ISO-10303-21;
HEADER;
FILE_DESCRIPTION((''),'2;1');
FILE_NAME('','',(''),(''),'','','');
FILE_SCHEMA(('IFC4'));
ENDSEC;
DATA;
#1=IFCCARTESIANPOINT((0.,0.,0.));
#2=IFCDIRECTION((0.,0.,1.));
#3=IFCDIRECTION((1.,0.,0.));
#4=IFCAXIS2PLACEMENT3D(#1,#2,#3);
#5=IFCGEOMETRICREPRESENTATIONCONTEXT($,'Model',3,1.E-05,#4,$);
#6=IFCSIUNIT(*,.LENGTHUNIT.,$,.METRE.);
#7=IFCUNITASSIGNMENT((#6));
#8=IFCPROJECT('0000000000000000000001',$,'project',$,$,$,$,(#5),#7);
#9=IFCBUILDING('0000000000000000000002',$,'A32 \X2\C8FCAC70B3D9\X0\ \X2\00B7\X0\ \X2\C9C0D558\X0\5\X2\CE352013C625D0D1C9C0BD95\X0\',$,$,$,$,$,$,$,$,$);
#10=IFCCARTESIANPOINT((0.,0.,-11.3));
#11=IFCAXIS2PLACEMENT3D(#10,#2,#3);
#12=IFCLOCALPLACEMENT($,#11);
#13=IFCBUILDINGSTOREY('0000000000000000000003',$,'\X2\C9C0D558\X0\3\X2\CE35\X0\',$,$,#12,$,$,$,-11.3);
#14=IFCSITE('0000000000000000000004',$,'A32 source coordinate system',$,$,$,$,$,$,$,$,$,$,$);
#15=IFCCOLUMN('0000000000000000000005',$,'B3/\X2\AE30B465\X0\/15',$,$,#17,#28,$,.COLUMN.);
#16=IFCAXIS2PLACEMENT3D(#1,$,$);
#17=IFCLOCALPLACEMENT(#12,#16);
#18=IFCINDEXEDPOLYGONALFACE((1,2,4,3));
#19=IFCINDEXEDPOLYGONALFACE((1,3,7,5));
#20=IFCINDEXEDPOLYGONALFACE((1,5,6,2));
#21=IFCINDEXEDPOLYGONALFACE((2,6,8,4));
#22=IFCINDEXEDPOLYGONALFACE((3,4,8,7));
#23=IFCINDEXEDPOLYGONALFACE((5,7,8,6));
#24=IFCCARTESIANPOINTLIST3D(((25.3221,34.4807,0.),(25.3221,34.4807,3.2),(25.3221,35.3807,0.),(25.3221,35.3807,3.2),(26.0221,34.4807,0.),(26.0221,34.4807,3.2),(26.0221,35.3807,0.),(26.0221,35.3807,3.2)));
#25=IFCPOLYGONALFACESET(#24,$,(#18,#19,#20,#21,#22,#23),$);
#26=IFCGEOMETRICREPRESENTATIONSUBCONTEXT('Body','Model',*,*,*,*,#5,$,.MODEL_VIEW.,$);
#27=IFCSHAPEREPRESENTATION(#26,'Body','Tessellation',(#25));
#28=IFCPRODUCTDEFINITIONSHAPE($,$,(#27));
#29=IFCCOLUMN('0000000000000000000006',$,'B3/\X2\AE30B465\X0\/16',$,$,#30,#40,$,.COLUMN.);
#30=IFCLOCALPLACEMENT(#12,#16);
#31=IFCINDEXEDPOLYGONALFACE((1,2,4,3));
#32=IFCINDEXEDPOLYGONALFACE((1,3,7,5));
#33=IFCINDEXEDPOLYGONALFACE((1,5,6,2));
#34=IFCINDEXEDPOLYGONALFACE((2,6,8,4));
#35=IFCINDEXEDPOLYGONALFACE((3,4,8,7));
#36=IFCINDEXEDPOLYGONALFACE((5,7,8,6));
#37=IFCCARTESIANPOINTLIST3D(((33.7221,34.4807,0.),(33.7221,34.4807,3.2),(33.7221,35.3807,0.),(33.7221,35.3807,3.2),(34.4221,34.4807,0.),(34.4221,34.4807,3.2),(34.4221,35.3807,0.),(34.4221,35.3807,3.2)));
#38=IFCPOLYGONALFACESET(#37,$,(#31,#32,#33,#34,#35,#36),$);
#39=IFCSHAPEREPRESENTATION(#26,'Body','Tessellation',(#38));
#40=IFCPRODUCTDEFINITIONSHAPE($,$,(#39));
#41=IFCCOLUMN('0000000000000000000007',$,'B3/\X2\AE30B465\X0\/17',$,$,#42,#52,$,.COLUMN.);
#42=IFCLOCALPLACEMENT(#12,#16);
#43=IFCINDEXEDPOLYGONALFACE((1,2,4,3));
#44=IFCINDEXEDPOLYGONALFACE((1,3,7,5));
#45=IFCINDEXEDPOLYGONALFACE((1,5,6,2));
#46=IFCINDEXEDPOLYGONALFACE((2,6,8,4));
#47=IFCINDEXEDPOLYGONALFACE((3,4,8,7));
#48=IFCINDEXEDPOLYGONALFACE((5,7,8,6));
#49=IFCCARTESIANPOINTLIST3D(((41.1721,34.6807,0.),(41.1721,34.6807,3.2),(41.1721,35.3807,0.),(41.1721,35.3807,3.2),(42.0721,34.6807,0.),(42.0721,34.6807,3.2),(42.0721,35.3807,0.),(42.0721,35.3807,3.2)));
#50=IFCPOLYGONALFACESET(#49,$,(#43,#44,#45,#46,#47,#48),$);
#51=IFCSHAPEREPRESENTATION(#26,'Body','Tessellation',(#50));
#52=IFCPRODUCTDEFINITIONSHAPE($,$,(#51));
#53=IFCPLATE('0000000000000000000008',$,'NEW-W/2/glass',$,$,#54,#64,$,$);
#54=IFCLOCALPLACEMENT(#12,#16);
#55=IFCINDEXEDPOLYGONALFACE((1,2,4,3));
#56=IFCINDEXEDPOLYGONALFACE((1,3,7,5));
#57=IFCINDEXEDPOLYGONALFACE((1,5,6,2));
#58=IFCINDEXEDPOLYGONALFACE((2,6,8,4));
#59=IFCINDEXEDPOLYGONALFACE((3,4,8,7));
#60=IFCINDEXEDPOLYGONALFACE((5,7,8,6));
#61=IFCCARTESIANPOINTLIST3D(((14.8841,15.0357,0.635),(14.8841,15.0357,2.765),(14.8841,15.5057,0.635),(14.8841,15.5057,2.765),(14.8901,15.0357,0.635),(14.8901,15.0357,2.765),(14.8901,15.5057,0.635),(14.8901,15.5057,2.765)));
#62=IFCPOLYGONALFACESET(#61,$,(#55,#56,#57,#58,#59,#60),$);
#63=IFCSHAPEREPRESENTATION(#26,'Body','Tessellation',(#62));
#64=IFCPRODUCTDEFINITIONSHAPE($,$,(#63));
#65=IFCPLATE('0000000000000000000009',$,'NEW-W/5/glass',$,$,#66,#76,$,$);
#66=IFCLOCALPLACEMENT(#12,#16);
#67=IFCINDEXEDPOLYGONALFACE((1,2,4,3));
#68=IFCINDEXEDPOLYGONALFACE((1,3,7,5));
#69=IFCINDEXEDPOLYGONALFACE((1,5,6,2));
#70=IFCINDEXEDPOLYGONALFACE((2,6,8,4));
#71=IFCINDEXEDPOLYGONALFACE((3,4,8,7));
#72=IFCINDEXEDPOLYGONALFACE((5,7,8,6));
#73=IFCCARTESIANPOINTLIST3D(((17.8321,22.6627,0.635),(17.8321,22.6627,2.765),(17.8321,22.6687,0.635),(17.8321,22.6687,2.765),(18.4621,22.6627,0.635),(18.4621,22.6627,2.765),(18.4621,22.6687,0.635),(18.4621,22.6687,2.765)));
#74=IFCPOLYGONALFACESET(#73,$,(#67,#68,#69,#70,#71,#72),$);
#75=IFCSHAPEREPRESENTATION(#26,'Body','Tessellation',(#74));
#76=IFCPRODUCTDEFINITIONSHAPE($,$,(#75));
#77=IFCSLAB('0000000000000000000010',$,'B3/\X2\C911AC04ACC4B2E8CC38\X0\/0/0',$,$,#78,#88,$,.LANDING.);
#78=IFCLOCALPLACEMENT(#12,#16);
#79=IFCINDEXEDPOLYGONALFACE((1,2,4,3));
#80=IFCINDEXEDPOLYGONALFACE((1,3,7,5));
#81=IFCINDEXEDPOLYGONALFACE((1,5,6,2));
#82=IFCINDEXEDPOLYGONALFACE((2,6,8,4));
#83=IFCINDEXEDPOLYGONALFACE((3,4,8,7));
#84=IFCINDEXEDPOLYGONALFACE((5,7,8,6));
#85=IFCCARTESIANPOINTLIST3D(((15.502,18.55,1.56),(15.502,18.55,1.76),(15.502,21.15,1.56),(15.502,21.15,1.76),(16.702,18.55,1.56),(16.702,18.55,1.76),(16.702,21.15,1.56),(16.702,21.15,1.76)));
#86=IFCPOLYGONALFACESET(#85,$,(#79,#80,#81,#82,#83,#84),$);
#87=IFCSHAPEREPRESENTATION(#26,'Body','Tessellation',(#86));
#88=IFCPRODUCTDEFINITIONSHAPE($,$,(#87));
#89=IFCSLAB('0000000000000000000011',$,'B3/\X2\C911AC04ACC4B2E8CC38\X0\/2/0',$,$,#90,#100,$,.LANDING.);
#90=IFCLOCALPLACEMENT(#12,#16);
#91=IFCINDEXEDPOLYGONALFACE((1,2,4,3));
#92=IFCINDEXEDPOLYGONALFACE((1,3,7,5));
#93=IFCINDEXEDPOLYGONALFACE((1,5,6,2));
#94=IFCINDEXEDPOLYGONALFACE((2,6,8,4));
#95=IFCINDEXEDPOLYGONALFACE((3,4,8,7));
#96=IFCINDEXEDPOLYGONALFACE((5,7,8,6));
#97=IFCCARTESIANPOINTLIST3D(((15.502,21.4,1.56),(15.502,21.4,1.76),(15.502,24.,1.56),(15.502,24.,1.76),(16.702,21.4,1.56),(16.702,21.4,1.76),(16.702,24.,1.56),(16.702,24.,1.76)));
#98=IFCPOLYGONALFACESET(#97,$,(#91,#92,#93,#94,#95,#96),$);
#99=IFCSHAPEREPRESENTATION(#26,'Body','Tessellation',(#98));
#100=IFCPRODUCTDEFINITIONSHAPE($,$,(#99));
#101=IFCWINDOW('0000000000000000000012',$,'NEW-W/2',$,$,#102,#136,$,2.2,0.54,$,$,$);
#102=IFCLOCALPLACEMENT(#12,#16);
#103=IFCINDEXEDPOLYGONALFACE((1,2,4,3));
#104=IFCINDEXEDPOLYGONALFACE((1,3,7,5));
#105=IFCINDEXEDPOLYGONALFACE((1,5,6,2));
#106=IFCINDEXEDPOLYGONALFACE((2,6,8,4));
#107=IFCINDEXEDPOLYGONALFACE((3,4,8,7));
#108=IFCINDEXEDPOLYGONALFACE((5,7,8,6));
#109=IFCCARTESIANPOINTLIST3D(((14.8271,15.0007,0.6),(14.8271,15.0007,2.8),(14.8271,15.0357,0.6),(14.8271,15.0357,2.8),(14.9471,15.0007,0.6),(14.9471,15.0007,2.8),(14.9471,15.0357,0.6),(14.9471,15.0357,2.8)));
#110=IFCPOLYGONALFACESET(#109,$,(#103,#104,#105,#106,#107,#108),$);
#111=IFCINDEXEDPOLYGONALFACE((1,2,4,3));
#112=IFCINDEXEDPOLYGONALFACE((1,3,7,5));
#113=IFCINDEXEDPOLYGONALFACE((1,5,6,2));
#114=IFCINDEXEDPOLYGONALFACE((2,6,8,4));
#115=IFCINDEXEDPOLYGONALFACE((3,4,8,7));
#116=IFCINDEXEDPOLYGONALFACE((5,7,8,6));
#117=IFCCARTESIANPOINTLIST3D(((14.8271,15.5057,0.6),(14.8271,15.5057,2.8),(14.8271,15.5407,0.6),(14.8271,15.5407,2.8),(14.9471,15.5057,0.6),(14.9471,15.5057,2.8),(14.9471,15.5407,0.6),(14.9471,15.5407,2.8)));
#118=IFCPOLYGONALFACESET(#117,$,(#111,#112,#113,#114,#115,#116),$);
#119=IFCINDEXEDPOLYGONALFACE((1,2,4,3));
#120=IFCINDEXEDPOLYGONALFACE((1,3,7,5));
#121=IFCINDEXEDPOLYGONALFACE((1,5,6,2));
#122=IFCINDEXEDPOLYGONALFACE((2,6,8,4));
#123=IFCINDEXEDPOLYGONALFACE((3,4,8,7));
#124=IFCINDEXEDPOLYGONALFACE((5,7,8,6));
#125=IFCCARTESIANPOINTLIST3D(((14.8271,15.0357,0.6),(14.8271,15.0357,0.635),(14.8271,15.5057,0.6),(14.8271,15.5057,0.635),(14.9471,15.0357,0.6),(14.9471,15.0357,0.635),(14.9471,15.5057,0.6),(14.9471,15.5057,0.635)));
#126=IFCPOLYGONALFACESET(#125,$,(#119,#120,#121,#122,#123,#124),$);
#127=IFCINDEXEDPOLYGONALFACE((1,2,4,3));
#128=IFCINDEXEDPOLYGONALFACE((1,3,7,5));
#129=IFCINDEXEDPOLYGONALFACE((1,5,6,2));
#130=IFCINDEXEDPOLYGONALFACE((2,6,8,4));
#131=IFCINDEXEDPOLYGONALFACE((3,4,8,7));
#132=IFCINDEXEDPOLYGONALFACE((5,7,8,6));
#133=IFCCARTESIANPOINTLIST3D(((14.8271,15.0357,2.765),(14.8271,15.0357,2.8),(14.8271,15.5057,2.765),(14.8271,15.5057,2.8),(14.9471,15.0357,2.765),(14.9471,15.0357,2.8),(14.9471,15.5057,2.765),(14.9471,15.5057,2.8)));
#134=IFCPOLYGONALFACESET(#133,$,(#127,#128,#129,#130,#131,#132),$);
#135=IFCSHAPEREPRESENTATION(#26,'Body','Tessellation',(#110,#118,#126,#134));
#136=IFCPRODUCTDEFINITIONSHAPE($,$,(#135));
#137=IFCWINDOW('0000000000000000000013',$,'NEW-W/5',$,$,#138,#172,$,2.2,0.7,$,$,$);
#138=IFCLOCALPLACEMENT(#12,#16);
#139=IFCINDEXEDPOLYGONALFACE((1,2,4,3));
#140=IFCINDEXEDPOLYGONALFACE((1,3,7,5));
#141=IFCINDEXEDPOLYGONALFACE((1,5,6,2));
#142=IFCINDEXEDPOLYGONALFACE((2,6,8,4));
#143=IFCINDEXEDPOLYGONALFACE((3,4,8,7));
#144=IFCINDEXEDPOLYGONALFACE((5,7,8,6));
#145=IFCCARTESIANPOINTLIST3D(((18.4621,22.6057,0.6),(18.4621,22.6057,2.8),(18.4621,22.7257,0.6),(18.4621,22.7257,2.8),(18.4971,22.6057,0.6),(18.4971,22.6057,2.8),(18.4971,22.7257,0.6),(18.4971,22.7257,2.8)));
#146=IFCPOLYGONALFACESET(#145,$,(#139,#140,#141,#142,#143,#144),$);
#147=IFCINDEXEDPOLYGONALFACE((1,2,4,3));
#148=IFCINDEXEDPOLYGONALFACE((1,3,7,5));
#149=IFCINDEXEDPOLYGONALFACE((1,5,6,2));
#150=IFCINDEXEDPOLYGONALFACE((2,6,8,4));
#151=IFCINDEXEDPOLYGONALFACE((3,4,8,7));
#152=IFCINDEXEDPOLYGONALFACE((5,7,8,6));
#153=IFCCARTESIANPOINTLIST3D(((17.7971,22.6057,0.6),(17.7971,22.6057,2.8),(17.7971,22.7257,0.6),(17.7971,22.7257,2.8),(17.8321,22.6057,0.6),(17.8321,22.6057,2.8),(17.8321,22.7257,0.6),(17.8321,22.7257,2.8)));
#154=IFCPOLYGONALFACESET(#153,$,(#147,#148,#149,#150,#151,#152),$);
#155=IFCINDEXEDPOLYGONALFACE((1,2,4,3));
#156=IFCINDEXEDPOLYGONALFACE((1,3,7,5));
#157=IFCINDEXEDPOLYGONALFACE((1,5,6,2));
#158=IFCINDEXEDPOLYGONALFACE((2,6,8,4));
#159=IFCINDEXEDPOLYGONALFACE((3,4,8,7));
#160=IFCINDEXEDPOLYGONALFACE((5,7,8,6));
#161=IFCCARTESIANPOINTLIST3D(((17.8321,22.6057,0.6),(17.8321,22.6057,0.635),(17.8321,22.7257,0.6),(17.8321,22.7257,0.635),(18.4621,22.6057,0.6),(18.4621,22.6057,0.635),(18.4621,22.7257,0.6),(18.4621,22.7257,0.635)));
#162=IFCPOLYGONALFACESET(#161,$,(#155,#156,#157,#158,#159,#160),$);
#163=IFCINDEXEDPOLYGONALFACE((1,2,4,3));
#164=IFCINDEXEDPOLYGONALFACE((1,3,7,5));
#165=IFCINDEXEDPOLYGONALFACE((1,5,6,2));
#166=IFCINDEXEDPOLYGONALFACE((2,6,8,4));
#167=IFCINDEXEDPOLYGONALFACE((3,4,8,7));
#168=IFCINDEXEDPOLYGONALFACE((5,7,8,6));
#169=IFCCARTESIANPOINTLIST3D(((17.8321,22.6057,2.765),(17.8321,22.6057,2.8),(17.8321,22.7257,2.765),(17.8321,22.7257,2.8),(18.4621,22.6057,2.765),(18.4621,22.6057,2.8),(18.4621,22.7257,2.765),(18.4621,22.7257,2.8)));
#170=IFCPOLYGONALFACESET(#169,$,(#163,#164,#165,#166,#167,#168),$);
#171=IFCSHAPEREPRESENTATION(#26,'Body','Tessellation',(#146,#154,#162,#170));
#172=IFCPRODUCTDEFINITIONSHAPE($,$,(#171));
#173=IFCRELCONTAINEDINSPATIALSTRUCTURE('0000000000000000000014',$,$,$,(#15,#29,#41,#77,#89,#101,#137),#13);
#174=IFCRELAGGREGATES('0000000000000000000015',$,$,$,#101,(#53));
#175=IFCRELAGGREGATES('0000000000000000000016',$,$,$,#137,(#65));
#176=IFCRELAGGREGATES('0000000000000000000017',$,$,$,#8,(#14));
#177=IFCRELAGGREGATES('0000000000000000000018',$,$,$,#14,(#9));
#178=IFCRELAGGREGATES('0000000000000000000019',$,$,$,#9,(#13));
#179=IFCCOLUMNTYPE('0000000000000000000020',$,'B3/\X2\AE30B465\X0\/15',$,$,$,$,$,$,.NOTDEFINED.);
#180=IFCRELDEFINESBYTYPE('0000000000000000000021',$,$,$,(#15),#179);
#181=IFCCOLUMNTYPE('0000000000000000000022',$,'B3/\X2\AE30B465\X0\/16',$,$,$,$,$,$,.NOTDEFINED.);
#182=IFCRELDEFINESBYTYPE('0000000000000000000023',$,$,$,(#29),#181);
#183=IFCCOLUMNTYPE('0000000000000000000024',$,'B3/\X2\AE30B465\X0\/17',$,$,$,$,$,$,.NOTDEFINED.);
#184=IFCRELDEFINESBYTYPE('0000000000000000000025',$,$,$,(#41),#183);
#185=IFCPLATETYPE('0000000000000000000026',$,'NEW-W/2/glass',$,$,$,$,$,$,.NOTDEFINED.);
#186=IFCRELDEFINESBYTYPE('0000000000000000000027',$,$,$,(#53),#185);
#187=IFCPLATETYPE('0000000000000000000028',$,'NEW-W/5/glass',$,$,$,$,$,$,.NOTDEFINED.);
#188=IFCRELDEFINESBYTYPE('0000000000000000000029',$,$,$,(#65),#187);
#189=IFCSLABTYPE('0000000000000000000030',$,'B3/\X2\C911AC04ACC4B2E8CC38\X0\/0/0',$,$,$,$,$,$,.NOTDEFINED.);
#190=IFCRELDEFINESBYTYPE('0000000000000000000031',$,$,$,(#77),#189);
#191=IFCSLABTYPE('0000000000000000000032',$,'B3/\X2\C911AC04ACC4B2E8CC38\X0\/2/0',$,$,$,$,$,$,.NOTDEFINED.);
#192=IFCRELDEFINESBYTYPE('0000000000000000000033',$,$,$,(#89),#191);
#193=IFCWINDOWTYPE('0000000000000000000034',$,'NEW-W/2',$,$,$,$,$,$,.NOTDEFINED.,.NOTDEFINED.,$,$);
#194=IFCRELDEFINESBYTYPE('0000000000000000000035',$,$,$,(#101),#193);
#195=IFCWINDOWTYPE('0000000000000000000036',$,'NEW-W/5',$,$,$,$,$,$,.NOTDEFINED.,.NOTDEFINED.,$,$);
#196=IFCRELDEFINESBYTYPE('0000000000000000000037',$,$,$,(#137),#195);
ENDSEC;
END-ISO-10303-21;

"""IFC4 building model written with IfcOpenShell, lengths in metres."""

from ifc_helpers import new_model, si_unit, frame, origin, origin_with_axes, place, context, subcontext, project, spatial, polyline, outline, extrude, source, transform, mapped, type_object, type_shapes, element, aggregate, save


model = new_model("IFC4")

# Units and contexts
model_context = context("Model", 3, precision=1e-05, world=origin_with_axes())
body_context = subcontext(model_context, "Body", "Model", "MODEL_VIEW")
ifc_project = project(units=[si_unit("LENGTHUNIT", "METRE")], contexts=[model_context])

# Site, building, storey
site = spatial("IfcSite", under=ifc_project, Name="A32 source coordinate system")
building = spatial("IfcBuilding", under=site, Name="A32 주거동 · 지하5층–옥탑지붕")
storey_placement = place(None, frame((0.0, 0.0, -11.3), z_axis=(0.0, 0.0, 1.0), x_axis=(1.0, 0.0, 0.0)))
storey = spatial("IfcBuildingStorey", under=building, at=storey_placement, Name="지하3층", Elevation=-11.3)

# Columns
column_type_1 = type_object("IfcColumnType", Name="B3/기둥/15", PredefinedType="NOTDEFINED")
shared_shape_1 = source(origin(), body_context, "Body", "SweptSolid", [
    extrude(outline(polyline([(26.0221, 34.4807), (25.3221, 34.4807), (25.3221, 35.3807), (26.0221, 35.3807), (26.0221, 34.4807)])), origin(), (0.0, 0.0, 1.0), 3.2),
])
type_shapes(column_type_1, [shared_shape_1])
column_1_placement = place(storey_placement, origin_with_axes())
element("IfcColumn", 1, at=column_1_placement, inside=storey, type_object=column_type_1, Name="B3/기둥/15", PredefinedType="COLUMN", context=body_context, shape_type="MappedRepresentation", body=[
    mapped(shared_shape_1, transform((0.0, 0.0, 0.0), scale=1.0)),
])
column_type_2 = type_object("IfcColumnType", Name="B3/기둥/16", PredefinedType="NOTDEFINED")
shared_shape_2 = source(origin(), body_context, "Body", "SweptSolid", [
    extrude(outline(polyline([(34.4221, 34.4807), (33.7221, 34.4807), (33.7221, 35.3807), (34.4221, 35.3807), (34.4221, 34.4807)])), origin(), (0.0, 0.0, 1.0), 3.2),
])
type_shapes(column_type_2, [shared_shape_2])
column_2_placement = place(storey_placement, origin_with_axes())
element("IfcColumn", 2, at=column_2_placement, inside=storey, type_object=column_type_2, Name="B3/기둥/16", PredefinedType="COLUMN", context=body_context, shape_type="MappedRepresentation", body=[
    mapped(shared_shape_2, transform((0.0, 0.0, 0.0), scale=1.0)),
])
column_type_3 = type_object("IfcColumnType", Name="B3/기둥/17", PredefinedType="NOTDEFINED")
shared_shape_3 = source(origin(), body_context, "Body", "SweptSolid", [
    extrude(outline(polyline([(42.0721, 35.3807), (42.0721, 34.6807), (41.1721, 34.6807), (41.1721, 35.3807), (42.0721, 35.3807)])), origin(), (0.0, 0.0, 1.0), 3.2),
])
type_shapes(column_type_3, [shared_shape_3])
column_3_placement = place(storey_placement, origin_with_axes())
element("IfcColumn", 3, at=column_3_placement, inside=storey, type_object=column_type_3, Name="B3/기둥/17", PredefinedType="COLUMN", context=body_context, shape_type="MappedRepresentation", body=[
    mapped(shared_shape_3, transform((0.0, 0.0, 0.0), scale=1.0)),
])

# Plates
plate_type_1 = type_object("IfcPlateType", Name="NEW-W/2/glass", PredefinedType="NOTDEFINED")
shared_shape_4 = source(origin(), body_context, "Body", "SweptSolid", [
    extrude(outline(polyline([(14.8901, 15.0357), (14.8841, 15.0357), (14.8841, 15.5057), (14.8901, 15.5057), (14.8901, 15.0357)])), frame((0.0, 0.0, 0.635)), (0.0, 0.0, 1.0), 2.13),
])
type_shapes(plate_type_1, [shared_shape_4])
window_1_placement = place(storey_placement, origin_with_axes())
plate_1_placement = place(window_1_placement, origin_with_axes())
plate_1 = element("IfcPlate", 4, at=plate_1_placement, type_object=plate_type_1, Name="NEW-W/2/glass", context=body_context, shape_type="MappedRepresentation", body=[
    mapped(shared_shape_4, transform((0.0, 0.0, 0.0), scale=1.0)),
])
plate_type_2 = type_object("IfcPlateType", Name="NEW-W/5/glass", PredefinedType="NOTDEFINED")
shared_shape_5 = source(origin(), body_context, "Body", "SweptSolid", [
    extrude(outline(polyline([(18.4621, 22.6627), (17.8321, 22.6627), (17.8321, 22.6687), (18.4621, 22.6687), (18.4621, 22.6627)])), frame((0.0, 0.0, 0.635)), (0.0, 0.0, 1.0), 2.13),
])
type_shapes(plate_type_2, [shared_shape_5])
window_2_placement = place(storey_placement, origin_with_axes())
plate_2_placement = place(window_2_placement, origin_with_axes())
plate_2 = element("IfcPlate", 5, at=plate_2_placement, type_object=plate_type_2, Name="NEW-W/5/glass", context=body_context, shape_type="MappedRepresentation", body=[
    mapped(shared_shape_5, transform((0.0, 0.0, 0.0), scale=1.0)),
])

# Slabs
slab_type_1 = type_object("IfcSlabType", Name="B3/중간계단참/0/0", PredefinedType="NOTDEFINED")
shared_shape_6 = source(origin(), body_context, "Body", "SweptSolid", [
    extrude(outline(polyline([(16.702, 18.55), (15.502, 18.55), (15.502, 21.15), (16.702, 21.15), (16.702, 18.55)])), frame((0.0, 0.0, 1.56)), (0.0, 0.0, 1.0), 0.2),
])
type_shapes(slab_type_1, [shared_shape_6])
slab_1_placement = place(storey_placement, origin_with_axes())
element("IfcSlab", 6, at=slab_1_placement, inside=storey, type_object=slab_type_1, Name="B3/중간계단참/0/0", PredefinedType="LANDING", context=body_context, shape_type="MappedRepresentation", body=[
    mapped(shared_shape_6, transform((0.0, 0.0, 0.0), scale=1.0)),
])
slab_type_2 = type_object("IfcSlabType", Name="B3/중간계단참/2/0", PredefinedType="NOTDEFINED")
shared_shape_7 = source(origin(), body_context, "Body", "SweptSolid", [
    extrude(outline(polyline([(16.702, 21.4), (15.502, 21.4), (15.502, 24.0), (16.702, 24.0), (16.702, 21.4)])), frame((0.0, 0.0, 1.56)), (0.0, 0.0, 1.0), 0.2),
])
type_shapes(slab_type_2, [shared_shape_7])
slab_2_placement = place(storey_placement, origin_with_axes())
element("IfcSlab", 7, at=slab_2_placement, inside=storey, type_object=slab_type_2, Name="B3/중간계단참/2/0", PredefinedType="LANDING", context=body_context, shape_type="MappedRepresentation", body=[
    mapped(shared_shape_7, transform((0.0, 0.0, 0.0), scale=1.0)),
])

# Windows
window_type_1 = type_object("IfcWindowType", Name="NEW-W/2", PartitioningType="NOTDEFINED", PredefinedType="NOTDEFINED")
shared_shape_8 = source(origin(), body_context, "Body", "SweptSolid", [
    extrude(outline(polyline([(14.8271, 15.0007), (14.8271, 15.0357), (14.9471, 15.0357), (14.9471, 15.0007), (14.8271, 15.0007)])), frame((0.0, 0.0, 0.6)), (0.0, 0.0, 1.0), 2.2),
    extrude(outline(polyline([(14.8271, 15.5057), (14.8271, 15.5407), (14.9471, 15.5407), (14.9471, 15.5057), (14.8271, 15.5057)])), frame((0.0, 0.0, 0.6)), (0.0, 0.0, 1.0), 2.2),
    extrude(outline(polyline([(14.9471, 15.0357), (14.9471, 15.5057), (14.8271, 15.5057), (14.8271, 15.0357), (14.9471, 15.0357)])), frame((0.0, 0.0, 0.6)), (0.0, 0.0, 1.0), 0.035),
    extrude(outline(polyline([(14.9471, 15.0357), (14.9471, 15.5057), (14.8271, 15.5057), (14.8271, 15.0357), (14.9471, 15.0357)])), frame((0.0, 0.0, 2.765)), (0.0, 0.0, 1.0), 0.035),
])
type_shapes(window_type_1, [shared_shape_8])
window_1 = element("IfcWindow", 8, at=window_1_placement, inside=storey, type_object=window_type_1, Name="NEW-W/2", OverallHeight=2.2, OverallWidth=0.54, context=body_context, shape_type="MappedRepresentation", body=[
    mapped(shared_shape_8, transform((0.0, 0.0, 0.0), scale=1.0)),
])
aggregate(window_1, [plate_1])
window_type_2 = type_object("IfcWindowType", Name="NEW-W/5", PartitioningType="NOTDEFINED", PredefinedType="NOTDEFINED")
shared_shape_9 = source(origin(), body_context, "Body", "SweptSolid", [
    extrude(outline(polyline([(18.4621, 22.6057), (18.4621, 22.7257), (18.4971, 22.7257), (18.4971, 22.6057), (18.4621, 22.6057)])), frame((0.0, 0.0, 0.6)), (0.0, 0.0, 1.0), 2.2),
    extrude(outline(polyline([(17.7971, 22.6057), (17.7971, 22.7257), (17.8321, 22.7257), (17.8321, 22.6057), (17.7971, 22.6057)])), frame((0.0, 0.0, 0.6)), (0.0, 0.0, 1.0), 2.2),
    extrude(outline(polyline([(18.4621, 22.6057), (18.4621, 22.7257), (17.8321, 22.7257), (17.8321, 22.6057), (18.4621, 22.6057)])), frame((0.0, 0.0, 0.6)), (0.0, 0.0, 1.0), 0.035),
    extrude(outline(polyline([(18.4621, 22.6057), (18.4621, 22.7257), (17.8321, 22.7257), (17.8321, 22.6057), (18.4621, 22.6057)])), frame((0.0, 0.0, 2.765)), (0.0, 0.0, 1.0), 0.035),
])
type_shapes(window_type_2, [shared_shape_9])
window_2 = element("IfcWindow", 9, at=window_2_placement, inside=storey, type_object=window_type_2, Name="NEW-W/5", OverallHeight=2.2, OverallWidth=0.7, context=body_context, shape_type="MappedRepresentation", body=[
    mapped(shared_shape_9, transform((0.0, 0.0, 0.0), scale=1.0)),
])
aggregate(window_2, [plate_2])

save(model, "model.ifc")
